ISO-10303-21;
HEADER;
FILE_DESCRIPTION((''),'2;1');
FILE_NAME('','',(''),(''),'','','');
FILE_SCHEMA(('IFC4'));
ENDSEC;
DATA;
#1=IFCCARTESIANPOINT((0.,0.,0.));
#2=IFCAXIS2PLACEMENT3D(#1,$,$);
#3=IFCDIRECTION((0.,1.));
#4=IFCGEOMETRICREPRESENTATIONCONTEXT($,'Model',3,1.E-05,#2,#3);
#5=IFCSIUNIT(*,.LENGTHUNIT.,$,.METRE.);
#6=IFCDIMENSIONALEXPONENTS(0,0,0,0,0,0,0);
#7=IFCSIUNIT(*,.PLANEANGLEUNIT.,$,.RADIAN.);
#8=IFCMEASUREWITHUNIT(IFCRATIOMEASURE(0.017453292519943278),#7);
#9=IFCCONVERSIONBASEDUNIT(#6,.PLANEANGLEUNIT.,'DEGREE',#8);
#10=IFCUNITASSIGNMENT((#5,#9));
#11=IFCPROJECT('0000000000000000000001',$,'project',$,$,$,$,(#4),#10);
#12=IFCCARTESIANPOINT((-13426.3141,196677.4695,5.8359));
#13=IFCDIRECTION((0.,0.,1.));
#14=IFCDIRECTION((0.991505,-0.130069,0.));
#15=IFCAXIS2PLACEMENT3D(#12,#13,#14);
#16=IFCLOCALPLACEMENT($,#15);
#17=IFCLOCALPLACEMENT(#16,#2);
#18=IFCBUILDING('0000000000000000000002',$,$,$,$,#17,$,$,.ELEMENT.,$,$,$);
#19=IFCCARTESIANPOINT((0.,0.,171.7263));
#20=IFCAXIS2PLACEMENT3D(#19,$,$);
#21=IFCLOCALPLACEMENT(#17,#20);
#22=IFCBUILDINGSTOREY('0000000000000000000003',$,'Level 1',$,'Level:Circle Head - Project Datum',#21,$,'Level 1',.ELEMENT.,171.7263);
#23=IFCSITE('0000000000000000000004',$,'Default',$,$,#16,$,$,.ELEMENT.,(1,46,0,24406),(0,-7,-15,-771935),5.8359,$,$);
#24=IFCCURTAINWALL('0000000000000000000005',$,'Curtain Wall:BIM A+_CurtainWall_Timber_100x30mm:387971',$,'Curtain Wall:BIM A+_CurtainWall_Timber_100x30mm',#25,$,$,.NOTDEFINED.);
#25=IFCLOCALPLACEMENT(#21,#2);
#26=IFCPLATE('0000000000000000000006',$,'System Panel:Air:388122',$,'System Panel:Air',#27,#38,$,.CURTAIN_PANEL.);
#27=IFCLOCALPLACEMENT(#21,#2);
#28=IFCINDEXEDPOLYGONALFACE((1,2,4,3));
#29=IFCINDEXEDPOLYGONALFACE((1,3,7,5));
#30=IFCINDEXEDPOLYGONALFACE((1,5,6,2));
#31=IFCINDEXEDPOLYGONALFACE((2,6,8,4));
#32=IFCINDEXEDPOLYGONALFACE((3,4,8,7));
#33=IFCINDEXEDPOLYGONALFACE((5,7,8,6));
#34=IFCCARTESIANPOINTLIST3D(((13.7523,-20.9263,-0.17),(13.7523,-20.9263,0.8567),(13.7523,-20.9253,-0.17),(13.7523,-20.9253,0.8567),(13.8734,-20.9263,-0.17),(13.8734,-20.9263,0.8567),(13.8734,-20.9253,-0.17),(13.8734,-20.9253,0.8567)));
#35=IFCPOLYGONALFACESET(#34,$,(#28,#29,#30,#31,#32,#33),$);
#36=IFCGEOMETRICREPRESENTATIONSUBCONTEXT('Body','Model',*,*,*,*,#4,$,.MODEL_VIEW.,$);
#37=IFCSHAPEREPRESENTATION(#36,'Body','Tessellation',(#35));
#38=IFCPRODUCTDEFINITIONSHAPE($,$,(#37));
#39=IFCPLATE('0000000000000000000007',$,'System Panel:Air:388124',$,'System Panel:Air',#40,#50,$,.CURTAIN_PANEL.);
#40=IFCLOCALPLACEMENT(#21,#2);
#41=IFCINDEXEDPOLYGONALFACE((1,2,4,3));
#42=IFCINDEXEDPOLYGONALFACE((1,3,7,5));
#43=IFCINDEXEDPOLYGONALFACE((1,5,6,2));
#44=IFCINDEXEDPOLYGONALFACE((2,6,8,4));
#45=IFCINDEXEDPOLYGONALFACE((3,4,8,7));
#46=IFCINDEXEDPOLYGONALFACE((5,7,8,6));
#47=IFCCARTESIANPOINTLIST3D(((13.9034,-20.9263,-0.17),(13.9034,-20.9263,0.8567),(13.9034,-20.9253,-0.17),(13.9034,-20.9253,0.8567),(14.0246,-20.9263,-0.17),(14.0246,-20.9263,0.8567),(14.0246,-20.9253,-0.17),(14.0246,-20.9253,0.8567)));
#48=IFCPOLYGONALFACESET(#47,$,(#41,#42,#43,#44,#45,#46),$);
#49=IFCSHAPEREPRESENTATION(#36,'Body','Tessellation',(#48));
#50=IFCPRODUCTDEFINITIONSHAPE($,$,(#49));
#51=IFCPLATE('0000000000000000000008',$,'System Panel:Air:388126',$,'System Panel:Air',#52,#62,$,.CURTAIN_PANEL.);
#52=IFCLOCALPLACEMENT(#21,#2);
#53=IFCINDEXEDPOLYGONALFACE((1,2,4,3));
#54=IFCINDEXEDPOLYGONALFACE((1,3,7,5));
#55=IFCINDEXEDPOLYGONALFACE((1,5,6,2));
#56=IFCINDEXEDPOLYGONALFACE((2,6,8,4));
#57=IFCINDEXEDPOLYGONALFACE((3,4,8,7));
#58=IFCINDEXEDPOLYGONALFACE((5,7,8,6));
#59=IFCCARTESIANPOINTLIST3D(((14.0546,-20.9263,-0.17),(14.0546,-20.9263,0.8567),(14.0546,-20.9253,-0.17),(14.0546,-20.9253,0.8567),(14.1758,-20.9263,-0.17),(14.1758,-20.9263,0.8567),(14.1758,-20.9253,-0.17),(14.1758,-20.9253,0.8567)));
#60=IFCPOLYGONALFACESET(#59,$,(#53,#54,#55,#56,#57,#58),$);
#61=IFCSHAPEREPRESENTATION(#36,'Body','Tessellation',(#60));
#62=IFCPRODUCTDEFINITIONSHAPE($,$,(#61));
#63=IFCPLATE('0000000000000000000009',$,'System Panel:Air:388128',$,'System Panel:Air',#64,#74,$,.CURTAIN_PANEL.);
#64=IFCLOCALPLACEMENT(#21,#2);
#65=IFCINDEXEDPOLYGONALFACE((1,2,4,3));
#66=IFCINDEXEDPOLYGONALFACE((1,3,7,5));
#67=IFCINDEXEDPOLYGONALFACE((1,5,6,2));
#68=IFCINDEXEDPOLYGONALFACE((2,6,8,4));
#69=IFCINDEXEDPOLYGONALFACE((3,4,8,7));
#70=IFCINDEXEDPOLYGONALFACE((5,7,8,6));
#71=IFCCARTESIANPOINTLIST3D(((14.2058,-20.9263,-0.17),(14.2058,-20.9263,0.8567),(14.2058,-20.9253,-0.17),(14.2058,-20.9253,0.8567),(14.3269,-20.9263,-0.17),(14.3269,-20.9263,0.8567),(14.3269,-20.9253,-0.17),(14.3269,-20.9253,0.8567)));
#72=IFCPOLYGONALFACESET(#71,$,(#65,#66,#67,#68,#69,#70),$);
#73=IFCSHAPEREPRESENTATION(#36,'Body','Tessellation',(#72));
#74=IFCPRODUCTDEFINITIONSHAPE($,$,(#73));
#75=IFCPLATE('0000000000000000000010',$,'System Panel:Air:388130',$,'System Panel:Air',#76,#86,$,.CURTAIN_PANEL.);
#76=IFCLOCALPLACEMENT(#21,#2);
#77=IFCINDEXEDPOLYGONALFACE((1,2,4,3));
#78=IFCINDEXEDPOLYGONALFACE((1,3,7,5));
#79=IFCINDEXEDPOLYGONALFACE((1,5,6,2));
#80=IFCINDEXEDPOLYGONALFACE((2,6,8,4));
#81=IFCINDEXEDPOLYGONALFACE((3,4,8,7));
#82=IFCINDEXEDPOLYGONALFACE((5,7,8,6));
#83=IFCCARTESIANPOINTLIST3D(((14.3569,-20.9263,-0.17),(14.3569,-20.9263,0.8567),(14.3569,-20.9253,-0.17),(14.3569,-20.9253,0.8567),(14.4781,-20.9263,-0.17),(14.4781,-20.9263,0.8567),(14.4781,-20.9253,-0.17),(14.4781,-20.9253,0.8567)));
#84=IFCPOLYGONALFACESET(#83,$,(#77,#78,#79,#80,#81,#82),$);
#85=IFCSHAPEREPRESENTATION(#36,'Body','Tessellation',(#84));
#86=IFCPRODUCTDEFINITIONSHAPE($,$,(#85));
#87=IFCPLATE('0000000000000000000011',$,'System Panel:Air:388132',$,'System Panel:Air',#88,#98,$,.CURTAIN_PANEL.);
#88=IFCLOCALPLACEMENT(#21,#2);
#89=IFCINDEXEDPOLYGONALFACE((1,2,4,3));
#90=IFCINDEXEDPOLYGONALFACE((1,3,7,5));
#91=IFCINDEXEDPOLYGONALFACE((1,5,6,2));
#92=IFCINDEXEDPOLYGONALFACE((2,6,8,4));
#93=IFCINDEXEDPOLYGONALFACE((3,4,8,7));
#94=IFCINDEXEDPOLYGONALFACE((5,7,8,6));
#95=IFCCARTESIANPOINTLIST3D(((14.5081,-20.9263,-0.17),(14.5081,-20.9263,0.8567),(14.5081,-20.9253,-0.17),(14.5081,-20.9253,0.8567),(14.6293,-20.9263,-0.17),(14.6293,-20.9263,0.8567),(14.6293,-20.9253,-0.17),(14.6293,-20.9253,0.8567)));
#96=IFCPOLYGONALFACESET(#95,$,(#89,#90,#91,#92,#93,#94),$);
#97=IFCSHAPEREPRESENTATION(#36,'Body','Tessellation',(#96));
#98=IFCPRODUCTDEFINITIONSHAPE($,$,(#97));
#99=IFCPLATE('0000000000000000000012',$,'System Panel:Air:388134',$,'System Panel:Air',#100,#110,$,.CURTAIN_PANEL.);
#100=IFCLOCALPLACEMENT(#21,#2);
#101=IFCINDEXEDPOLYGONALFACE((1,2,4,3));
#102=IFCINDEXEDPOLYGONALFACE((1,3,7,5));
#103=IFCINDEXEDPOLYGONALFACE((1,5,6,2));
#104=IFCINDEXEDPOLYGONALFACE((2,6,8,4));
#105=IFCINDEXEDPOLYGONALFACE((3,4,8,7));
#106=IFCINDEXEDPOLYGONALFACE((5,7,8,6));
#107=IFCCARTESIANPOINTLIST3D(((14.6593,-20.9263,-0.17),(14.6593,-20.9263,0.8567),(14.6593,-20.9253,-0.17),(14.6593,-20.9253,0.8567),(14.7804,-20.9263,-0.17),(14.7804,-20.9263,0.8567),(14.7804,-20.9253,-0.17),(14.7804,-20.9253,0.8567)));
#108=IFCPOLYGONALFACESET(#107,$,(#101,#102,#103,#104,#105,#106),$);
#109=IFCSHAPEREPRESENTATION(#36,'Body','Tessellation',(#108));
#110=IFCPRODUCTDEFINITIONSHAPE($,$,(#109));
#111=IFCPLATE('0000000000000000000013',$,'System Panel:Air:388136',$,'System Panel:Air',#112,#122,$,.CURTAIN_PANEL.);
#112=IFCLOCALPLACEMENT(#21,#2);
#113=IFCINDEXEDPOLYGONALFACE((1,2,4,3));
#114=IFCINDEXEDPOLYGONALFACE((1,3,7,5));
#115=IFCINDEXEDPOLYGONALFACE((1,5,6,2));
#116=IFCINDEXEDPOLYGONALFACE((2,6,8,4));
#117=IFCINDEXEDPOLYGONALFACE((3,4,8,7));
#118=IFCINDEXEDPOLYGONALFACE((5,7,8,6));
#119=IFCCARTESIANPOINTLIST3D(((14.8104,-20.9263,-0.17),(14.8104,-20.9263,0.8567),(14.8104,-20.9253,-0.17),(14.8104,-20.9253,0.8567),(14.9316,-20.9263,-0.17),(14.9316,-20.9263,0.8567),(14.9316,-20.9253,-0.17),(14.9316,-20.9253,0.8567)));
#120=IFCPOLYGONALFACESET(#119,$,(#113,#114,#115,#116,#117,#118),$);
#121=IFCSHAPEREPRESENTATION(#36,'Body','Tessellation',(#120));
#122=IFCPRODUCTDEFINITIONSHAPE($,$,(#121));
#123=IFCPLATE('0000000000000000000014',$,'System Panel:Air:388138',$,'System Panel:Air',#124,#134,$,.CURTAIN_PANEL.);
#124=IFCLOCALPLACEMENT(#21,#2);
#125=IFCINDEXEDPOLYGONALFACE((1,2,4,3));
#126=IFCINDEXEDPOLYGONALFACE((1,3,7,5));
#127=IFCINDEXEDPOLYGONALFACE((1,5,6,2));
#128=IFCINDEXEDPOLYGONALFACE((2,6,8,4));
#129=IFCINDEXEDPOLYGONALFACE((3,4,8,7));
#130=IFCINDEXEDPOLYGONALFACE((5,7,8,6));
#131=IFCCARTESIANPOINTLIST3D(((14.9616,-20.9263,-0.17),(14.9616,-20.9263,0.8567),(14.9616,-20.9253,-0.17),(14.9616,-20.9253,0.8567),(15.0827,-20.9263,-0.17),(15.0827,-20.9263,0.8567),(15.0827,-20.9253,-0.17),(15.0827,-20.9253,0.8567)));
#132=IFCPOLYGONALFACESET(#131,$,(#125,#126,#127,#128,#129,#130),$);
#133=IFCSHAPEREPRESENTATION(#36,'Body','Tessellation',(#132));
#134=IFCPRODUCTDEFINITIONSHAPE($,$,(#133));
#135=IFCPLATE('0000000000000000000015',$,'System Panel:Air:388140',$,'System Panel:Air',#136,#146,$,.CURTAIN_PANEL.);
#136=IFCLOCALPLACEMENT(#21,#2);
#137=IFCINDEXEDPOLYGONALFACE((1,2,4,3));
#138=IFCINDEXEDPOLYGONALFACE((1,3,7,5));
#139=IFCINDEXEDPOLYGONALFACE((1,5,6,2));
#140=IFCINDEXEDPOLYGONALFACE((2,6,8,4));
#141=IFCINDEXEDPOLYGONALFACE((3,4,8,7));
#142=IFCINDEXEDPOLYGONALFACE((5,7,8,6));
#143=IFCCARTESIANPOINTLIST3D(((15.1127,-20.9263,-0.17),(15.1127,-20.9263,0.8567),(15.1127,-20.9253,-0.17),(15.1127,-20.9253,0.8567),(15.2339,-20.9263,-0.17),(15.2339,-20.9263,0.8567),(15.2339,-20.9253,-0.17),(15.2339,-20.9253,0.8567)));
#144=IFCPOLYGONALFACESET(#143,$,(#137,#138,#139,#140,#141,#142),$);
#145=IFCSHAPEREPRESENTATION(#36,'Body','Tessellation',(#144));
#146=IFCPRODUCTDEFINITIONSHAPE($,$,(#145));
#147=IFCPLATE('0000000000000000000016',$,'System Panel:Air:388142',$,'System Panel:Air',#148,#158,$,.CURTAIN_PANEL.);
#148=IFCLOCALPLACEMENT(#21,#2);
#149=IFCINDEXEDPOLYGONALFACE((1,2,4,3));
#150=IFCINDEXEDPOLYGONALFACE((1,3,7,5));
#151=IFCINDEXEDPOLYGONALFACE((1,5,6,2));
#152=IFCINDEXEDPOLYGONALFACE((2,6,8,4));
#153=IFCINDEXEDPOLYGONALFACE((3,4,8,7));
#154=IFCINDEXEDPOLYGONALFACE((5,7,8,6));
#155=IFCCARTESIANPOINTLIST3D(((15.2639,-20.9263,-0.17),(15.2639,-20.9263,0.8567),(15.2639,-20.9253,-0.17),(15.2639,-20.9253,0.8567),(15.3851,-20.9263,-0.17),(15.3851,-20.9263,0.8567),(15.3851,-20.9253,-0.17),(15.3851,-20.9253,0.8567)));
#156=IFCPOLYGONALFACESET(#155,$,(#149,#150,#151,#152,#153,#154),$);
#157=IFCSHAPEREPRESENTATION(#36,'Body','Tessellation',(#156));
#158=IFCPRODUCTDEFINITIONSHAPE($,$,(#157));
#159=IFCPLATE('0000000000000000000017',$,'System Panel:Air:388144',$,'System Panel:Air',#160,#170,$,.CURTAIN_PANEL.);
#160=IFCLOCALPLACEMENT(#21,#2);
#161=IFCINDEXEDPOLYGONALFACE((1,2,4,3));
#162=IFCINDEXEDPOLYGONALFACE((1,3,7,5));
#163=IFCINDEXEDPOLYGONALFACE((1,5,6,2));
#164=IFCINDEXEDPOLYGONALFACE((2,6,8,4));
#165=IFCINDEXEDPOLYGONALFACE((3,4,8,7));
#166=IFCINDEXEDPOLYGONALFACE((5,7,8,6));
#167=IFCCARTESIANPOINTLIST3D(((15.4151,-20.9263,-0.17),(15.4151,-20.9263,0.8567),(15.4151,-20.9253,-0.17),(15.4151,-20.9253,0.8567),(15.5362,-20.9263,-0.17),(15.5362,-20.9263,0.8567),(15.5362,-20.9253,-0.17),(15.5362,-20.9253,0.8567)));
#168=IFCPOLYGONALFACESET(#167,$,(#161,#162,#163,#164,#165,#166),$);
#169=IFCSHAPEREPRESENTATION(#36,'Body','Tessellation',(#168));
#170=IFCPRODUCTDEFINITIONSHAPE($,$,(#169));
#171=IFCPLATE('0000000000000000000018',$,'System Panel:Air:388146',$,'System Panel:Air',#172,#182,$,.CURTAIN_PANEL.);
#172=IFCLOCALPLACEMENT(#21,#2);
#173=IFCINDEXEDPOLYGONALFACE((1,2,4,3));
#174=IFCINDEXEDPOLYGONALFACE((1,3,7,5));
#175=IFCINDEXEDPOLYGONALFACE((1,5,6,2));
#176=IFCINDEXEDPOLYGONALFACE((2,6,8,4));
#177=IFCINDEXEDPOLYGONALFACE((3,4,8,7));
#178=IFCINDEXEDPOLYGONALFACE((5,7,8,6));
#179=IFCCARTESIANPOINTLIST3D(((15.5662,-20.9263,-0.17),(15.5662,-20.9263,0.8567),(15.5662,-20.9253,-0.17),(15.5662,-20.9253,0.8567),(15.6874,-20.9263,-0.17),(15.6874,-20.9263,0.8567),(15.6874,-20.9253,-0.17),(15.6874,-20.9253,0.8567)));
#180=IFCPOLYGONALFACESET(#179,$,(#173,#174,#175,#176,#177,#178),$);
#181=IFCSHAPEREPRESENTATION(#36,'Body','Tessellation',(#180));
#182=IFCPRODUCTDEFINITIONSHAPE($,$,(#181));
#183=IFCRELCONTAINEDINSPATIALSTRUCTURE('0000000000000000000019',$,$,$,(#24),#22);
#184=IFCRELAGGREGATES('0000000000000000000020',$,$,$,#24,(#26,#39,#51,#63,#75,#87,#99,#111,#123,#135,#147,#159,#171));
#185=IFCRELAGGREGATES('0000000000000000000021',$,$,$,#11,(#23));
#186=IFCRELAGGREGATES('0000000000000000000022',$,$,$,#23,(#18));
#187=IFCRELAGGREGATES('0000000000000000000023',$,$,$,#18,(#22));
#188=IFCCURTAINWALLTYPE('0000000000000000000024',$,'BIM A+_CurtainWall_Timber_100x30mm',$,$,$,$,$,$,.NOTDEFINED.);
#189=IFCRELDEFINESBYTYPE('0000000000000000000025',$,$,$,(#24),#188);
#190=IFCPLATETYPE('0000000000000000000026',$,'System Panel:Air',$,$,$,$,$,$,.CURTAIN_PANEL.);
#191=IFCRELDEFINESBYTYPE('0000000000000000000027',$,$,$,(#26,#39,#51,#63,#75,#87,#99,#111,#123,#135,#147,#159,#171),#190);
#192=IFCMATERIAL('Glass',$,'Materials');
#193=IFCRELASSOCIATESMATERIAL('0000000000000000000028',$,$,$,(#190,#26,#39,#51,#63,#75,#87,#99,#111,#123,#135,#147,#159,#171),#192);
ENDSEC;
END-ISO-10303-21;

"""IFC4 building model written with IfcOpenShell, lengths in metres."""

from ifc_helpers import new_model, entity, si_unit, converted_unit, direction, frame, origin, place, context, subcontext, project, spatial, indexed_curve, outline, extrude, source, transform, mapped, material, type_object, type_shapes, element, aggregate, save


model = new_model("IFC4")

# Units and contexts
model_context = context("Model", 3, precision=1e-05, world=origin(), true_north=direction((0.0, 1.0)))
body_context = subcontext(model_context, "Body", "Model", "MODEL_VIEW")
ifc_project = project(units=[si_unit("LENGTHUNIT", "METRE"), converted_unit("PLANEANGLEUNIT", "DEGREE", entity("IfcRatioMeasure", 0.017453292519943278), si_unit("PLANEANGLEUNIT", "RADIAN"), dimensions=[0, 0, 0, 0, 0, 0, 0])], contexts=[model_context])

# Site, building, storey
site_placement = place(None, frame((-13426.3141, 196677.4695, 5.8359), z_axis=(0.0, 0.0, 1.0), x_axis=(0.991505, -0.130069, 0.0)))
site = spatial("IfcSite", under=ifc_project, at=site_placement, Name="Default", CompositionType="ELEMENT", RefLatitude=(1, 46, 0, 24406), RefLongitude=(0, -7, -15, -771935), RefElevation=5.8359)
building_placement = place(site_placement, origin())
building = spatial("IfcBuilding", under=site, at=building_placement, CompositionType="ELEMENT")
storey_placement = place(building_placement, frame((0.0, 0.0, 171.7263)))
storey = spatial("IfcBuildingStorey", under=building, at=storey_placement, Name="Level 1", ObjectType="Level:Circle Head - Project Datum", LongName="Level 1", CompositionType="ELEMENT", Elevation=171.7263)

# Shared definitions
ifc_material_1 = material(Name="Glass", Category="Materials")

# Curtain wall, plates
curtain_wall_type_1 = type_object("IfcCurtainWallType", Name="BIM A+_CurtainWall_Timber_100x30mm", PredefinedType="NOTDEFINED")
curtain_wall_1_placement = place(storey_placement, frame((0.0, 0.0, -171.7263)))
curtain_wall_1 = element("IfcCurtainWall", 1, at=curtain_wall_1_placement, inside=storey, type_object=curtain_wall_type_1, Name="Curtain Wall:BIM A+_CurtainWall_Timber_100x30mm:387971", ObjectType="Curtain Wall:BIM A+_CurtainWall_Timber_100x30mm", PredefinedType="NOTDEFINED")
plate_type_1 = type_object("IfcPlateType", Name="System Panel:Air", PredefinedType="CURTAIN_PANEL", material=ifc_material_1)
shared_shape_1 = source(origin(), body_context, "Body", "SweptSolid", [
    extrude(outline(indexed_curve([(-0.0005, -0.0606), (0.0005, -0.0606), (0.0005, 0.0606), (-0.0005, 0.0606), (-0.0005, -0.0606)], self_intersect=False)), frame((0.0, 0.0, 0.0), z_axis=(0.0, 0.0, 1.0), x_axis=(0.0, 1.0, 0.0)), (0.0, 0.0, 1.0), 1.0267),
])
type_shapes(plate_type_1, [shared_shape_1])
plate_1_placement = place(curtain_wall_1_placement, frame((13.8129, -20.9258, 171.5563)))
plate_1 = element("IfcPlate", 2, at=plate_1_placement, type_object=plate_type_1, material=ifc_material_1, Name="System Panel:Air:388122", ObjectType="System Panel:Air", PredefinedType="CURTAIN_PANEL", context=body_context, shape_type="MappedRepresentation", body=[
    mapped(shared_shape_1, transform((0.0, 0.0, 0.0), scale=1.0)),
])
plate_2_placement = place(curtain_wall_1_placement, frame((13.964, -20.9258, 171.5563)))
plate_2 = element("IfcPlate", 3, at=plate_2_placement, type_object=plate_type_1, material=ifc_material_1, Name="System Panel:Air:388124", ObjectType="System Panel:Air", PredefinedType="CURTAIN_PANEL", context=body_context, shape_type="MappedRepresentation", body=[
    mapped(shared_shape_1, transform((0.0, 0.0, 0.0), scale=1.0)),
])
plate_3_placement = place(curtain_wall_1_placement, frame((14.1152, -20.9258, 171.5563)))
plate_3 = element("IfcPlate", 4, at=plate_3_placement, type_object=plate_type_1, material=ifc_material_1, Name="System Panel:Air:388126", ObjectType="System Panel:Air", PredefinedType="CURTAIN_PANEL", context=body_context, shape_type="MappedRepresentation", body=[
    mapped(shared_shape_1, transform((0.0, 0.0, 0.0), scale=1.0)),
])
plate_4_placement = place(curtain_wall_1_placement, frame((14.2664, -20.9258, 171.5563)))
plate_4 = element("IfcPlate", 5, at=plate_4_placement, type_object=plate_type_1, material=ifc_material_1, Name="System Panel:Air:388128", ObjectType="System Panel:Air", PredefinedType="CURTAIN_PANEL", context=body_context, shape_type="MappedRepresentation", body=[
    mapped(shared_shape_1, transform((0.0, 0.0, 0.0), scale=1.0)),
])
plate_5_placement = place(curtain_wall_1_placement, frame((14.4175, -20.9258, 171.5563)))
plate_5 = element("IfcPlate", 6, at=plate_5_placement, type_object=plate_type_1, material=ifc_material_1, Name="System Panel:Air:388130", ObjectType="System Panel:Air", PredefinedType="CURTAIN_PANEL", context=body_context, shape_type="MappedRepresentation", body=[
    mapped(shared_shape_1, transform((0.0, 0.0, 0.0), scale=1.0)),
])
plate_6_placement = place(curtain_wall_1_placement, frame((14.5687, -20.9258, 171.5563)))
plate_6 = element("IfcPlate", 7, at=plate_6_placement, type_object=plate_type_1, material=ifc_material_1, Name="System Panel:Air:388132", ObjectType="System Panel:Air", PredefinedType="CURTAIN_PANEL", context=body_context, shape_type="MappedRepresentation", body=[
    mapped(shared_shape_1, transform((0.0, 0.0, 0.0), scale=1.0)),
])
plate_7_placement = place(curtain_wall_1_placement, frame((14.7198, -20.9258, 171.5563)))
plate_7 = element("IfcPlate", 8, at=plate_7_placement, type_object=plate_type_1, material=ifc_material_1, Name="System Panel:Air:388134", ObjectType="System Panel:Air", PredefinedType="CURTAIN_PANEL", context=body_context, shape_type="MappedRepresentation", body=[
    mapped(shared_shape_1, transform((0.0, 0.0, 0.0), scale=1.0)),
])
plate_8_placement = place(curtain_wall_1_placement, frame((14.871, -20.9258, 171.5563)))
plate_8 = element("IfcPlate", 9, at=plate_8_placement, type_object=plate_type_1, material=ifc_material_1, Name="System Panel:Air:388136", ObjectType="System Panel:Air", PredefinedType="CURTAIN_PANEL", context=body_context, shape_type="MappedRepresentation", body=[
    mapped(shared_shape_1, transform((0.0, 0.0, 0.0), scale=1.0)),
])
plate_9_placement = place(curtain_wall_1_placement, frame((15.0222, -20.9258, 171.5563)))
plate_9 = element("IfcPlate", 10, at=plate_9_placement, type_object=plate_type_1, material=ifc_material_1, Name="System Panel:Air:388138", ObjectType="System Panel:Air", PredefinedType="CURTAIN_PANEL", context=body_context, shape_type="MappedRepresentation", body=[
    mapped(shared_shape_1, transform((0.0, 0.0, 0.0), scale=1.0)),
])
plate_10_placement = place(curtain_wall_1_placement, frame((15.1733, -20.9258, 171.5563)))
plate_10 = element("IfcPlate", 11, at=plate_10_placement, type_object=plate_type_1, material=ifc_material_1, Name="System Panel:Air:388140", ObjectType="System Panel:Air", PredefinedType="CURTAIN_PANEL", context=body_context, shape_type="MappedRepresentation", body=[
    mapped(shared_shape_1, transform((0.0, 0.0, 0.0), scale=1.0)),
])
plate_11_placement = place(curtain_wall_1_placement, frame((15.3245, -20.9258, 171.5563)))
plate_11 = element("IfcPlate", 12, at=plate_11_placement, type_object=plate_type_1, material=ifc_material_1, Name="System Panel:Air:388142", ObjectType="System Panel:Air", PredefinedType="CURTAIN_PANEL", context=body_context, shape_type="MappedRepresentation", body=[
    mapped(shared_shape_1, transform((0.0, 0.0, 0.0), scale=1.0)),
])
plate_12_placement = place(curtain_wall_1_placement, frame((15.4757, -20.9258, 171.5563)))
plate_12 = element("IfcPlate", 13, at=plate_12_placement, type_object=plate_type_1, material=ifc_material_1, Name="System Panel:Air:388144", ObjectType="System Panel:Air", PredefinedType="CURTAIN_PANEL", context=body_context, shape_type="MappedRepresentation", body=[
    mapped(shared_shape_1, transform((0.0, 0.0, 0.0), scale=1.0)),
])
plate_13_placement = place(curtain_wall_1_placement, frame((15.6268, -20.9258, 171.5563)))
plate_13 = element("IfcPlate", 14, at=plate_13_placement, type_object=plate_type_1, material=ifc_material_1, Name="System Panel:Air:388146", ObjectType="System Panel:Air", PredefinedType="CURTAIN_PANEL", context=body_context, shape_type="MappedRepresentation", body=[
    mapped(shared_shape_1, transform((0.0, 0.0, 0.0), scale=1.0)),
])
aggregate(curtain_wall_1, [plate_1, plate_2, plate_3, plate_4, plate_5, plate_6, plate_7, plate_8, plate_9, plate_10, plate_11, plate_12, plate_13])

save(model, "model.ifc")
